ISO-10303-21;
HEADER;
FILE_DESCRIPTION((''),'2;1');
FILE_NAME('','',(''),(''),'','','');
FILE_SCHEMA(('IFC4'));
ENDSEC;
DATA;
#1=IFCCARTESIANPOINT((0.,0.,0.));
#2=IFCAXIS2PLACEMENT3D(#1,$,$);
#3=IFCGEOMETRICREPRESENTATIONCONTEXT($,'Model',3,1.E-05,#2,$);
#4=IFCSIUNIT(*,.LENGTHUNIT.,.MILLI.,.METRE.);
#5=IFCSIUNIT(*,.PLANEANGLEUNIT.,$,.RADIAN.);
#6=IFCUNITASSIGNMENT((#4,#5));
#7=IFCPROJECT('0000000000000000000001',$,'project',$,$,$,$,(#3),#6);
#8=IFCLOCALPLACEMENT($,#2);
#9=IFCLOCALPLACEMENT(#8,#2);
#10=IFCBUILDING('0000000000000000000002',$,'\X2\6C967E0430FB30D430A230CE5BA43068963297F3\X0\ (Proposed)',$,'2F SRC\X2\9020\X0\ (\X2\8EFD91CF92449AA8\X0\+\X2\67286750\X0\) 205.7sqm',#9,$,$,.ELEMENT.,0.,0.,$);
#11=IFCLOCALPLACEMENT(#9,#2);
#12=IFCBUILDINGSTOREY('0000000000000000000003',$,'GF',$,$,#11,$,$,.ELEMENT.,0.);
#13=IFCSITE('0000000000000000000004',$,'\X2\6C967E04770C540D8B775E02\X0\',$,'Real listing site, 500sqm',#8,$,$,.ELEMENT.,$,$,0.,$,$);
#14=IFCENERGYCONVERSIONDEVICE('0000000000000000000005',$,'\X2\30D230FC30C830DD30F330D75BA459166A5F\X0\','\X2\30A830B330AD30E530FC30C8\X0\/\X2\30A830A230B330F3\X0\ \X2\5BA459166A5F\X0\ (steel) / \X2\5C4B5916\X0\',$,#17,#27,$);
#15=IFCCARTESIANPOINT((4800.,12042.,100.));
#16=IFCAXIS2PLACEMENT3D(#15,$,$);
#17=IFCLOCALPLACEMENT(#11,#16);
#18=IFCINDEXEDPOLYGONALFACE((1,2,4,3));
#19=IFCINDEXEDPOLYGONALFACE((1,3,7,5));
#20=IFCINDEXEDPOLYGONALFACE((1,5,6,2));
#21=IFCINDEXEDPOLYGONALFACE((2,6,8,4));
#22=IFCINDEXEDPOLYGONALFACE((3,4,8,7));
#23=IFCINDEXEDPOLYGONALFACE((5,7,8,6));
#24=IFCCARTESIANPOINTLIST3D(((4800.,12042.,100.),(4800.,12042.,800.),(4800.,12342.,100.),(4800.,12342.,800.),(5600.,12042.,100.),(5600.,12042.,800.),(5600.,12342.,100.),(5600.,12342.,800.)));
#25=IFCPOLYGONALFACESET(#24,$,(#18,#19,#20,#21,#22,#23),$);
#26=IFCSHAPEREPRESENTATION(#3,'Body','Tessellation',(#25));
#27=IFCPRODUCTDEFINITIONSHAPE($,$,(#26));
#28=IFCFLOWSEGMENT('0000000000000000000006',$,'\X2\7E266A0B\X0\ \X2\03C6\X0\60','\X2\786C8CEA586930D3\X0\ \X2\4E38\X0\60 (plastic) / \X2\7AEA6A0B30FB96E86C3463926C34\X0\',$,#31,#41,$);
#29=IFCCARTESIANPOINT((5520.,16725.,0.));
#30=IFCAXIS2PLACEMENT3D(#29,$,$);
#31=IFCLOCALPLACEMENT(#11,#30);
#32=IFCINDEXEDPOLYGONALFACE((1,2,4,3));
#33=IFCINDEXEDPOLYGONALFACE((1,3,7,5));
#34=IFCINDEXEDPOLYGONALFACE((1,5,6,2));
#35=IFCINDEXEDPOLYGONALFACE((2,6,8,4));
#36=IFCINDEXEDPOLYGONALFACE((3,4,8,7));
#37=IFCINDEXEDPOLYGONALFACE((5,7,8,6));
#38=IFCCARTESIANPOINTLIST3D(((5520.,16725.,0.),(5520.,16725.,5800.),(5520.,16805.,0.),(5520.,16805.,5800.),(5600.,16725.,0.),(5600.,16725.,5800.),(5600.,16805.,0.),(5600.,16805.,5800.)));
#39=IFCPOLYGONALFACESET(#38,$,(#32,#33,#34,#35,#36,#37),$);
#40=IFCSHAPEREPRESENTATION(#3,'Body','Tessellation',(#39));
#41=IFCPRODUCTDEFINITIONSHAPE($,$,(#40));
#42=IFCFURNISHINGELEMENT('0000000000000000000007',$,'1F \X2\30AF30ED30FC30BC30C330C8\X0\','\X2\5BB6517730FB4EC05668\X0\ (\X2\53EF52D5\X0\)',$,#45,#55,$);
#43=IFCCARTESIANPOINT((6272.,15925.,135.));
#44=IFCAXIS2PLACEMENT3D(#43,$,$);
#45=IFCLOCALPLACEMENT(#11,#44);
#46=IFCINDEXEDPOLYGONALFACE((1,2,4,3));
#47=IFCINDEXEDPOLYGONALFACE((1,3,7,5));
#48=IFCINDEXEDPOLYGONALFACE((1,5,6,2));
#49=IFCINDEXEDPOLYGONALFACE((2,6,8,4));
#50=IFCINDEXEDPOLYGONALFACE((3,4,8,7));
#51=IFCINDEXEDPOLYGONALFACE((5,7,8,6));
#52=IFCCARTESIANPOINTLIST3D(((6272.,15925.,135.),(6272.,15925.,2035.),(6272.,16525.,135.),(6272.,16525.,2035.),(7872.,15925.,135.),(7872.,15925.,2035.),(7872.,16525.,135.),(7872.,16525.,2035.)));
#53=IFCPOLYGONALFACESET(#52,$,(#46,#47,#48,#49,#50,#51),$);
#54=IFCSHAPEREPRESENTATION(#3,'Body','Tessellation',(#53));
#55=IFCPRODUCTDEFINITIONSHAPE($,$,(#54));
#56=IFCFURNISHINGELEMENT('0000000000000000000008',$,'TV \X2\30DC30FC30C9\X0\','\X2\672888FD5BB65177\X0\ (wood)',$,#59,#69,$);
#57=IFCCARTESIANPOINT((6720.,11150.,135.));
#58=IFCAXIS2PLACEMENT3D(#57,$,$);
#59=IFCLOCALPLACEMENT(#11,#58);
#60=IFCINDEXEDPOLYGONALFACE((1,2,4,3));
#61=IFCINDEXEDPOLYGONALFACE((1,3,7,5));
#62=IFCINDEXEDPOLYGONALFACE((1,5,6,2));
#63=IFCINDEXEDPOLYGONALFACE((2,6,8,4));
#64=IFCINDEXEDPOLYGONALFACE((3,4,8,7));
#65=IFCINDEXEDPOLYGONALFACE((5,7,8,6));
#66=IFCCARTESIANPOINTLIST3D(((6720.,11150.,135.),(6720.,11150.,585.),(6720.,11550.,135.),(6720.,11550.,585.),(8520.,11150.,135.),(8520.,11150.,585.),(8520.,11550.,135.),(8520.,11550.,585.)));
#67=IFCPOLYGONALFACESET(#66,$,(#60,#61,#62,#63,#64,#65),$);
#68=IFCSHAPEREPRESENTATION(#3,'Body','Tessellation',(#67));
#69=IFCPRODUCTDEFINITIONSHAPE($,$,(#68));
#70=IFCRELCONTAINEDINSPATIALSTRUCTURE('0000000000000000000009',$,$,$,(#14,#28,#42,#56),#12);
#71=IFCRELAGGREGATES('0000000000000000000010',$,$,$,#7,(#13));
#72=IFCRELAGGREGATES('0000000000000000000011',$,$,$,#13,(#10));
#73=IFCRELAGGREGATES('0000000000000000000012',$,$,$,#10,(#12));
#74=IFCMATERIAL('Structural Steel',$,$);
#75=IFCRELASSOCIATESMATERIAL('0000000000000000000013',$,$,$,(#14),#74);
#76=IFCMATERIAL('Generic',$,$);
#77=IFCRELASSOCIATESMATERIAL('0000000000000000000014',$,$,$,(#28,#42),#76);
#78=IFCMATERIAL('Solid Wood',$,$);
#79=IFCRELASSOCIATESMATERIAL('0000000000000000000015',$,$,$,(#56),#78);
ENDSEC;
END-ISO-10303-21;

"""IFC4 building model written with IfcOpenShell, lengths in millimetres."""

from ifc_helpers import new_model, si_unit, frame, frame_2d, origin, place, context, project, spatial, rectangle, extrude, material, element, save


model = new_model("IFC4")

# Units and contexts
model_context = context("Model", 3, precision=1e-05, world=origin())
ifc_project = project(units=[si_unit("LENGTHUNIT", "METRE", prefix="MILLI"), si_unit("PLANEANGLEUNIT", "RADIAN")], contexts=[model_context])

# Site, building, storey
site_placement = place(None, origin())
site = spatial("IfcSite", under=ifc_project, at=site_placement, Name="沖縄県名護市", ObjectType="Real listing site, 500sqm", CompositionType="ELEMENT", RefElevation=0.0)
building_placement = place(site_placement, origin())
building = spatial("IfcBuilding", under=site, at=building_placement, Name="沖縄・ピアノ室と防音 (Proposed)", ObjectType="2F SRC造 (軽量鉄骨+木材) 205.7sqm", CompositionType="ELEMENT", ElevationOfRefHeight=0.0, ElevationOfTerrain=0.0)
storey_placement = place(building_placement, origin())
storey = spatial("IfcBuildingStorey", under=building, at=storey_placement, Name="GF", CompositionType="ELEMENT", Elevation=0.0)

# Shared definitions
ifc_material_1 = material(Name="Solid Wood")

# Shared definitions
ifc_material_2 = material(Name="Generic")

# Energy conversion device
ifc_material_3 = material(Name="Structural Steel")
energy_conversion_device_placement = place(storey_placement, frame((4800.0, 12042.0, 100.0)))
element("IfcEnergyConversionDevice", 1, at=energy_conversion_device_placement, inside=storey, material=ifc_material_3, Name="ヒートポンプ室外機", Description="エコキュート/エアコン 室外機 (steel) / 屋外", context=model_context, shape_type="SweptSolid", body=[
    extrude(rectangle(XDim=800.0, YDim=300.0, at=frame_2d((400.0, 150.0))), frame((4800.0, 12042.0, 100.0)), (0.0, 0.0, 1.0), 700.0),
])

# Flow segment
flow_segment_placement = place(storey_placement, frame((5520.0, 16725.0, 0.0)))
element("IfcFlowSegment", 2, at=flow_segment_placement, inside=storey, material=ifc_material_2, Name="縦樋 φ60", Description="硬質塩ビ 丸60 (plastic) / 竪樋・雨水排水", context=model_context, shape_type="SweptSolid", body=[
    extrude(rectangle(XDim=80.0, YDim=80.0, at=frame_2d((40.0, 40.0))), frame((5520.0, 16725.0, 0.0)), (0.0, 0.0, 1.0), 5800.0),
])

# Furnishing elements
furnishing_1_placement = place(storey_placement, frame((6272.0, 15925.0, 135.0)))
element("IfcFurnishingElement", 3, at=furnishing_1_placement, inside=storey, material=ifc_material_2, Name="1F クローゼット", Description="家具・什器 (可動)", context=model_context, shape_type="SweptSolid", body=[
    extrude(rectangle(XDim=1600.0, YDim=600.0, at=frame_2d((800.0, 300.0))), frame((6272.0, 15925.0, 135.0)), (0.0, 0.0, 1.0), 1900.0),
])
furnishing_2_placement = place(storey_placement, frame((6720.0, 11150.0, 135.0)))
element("IfcFurnishingElement", 4, at=furnishing_2_placement, inside=storey, material=ifc_material_1, Name="TV ボード", Description="木製家具 (wood)", context=model_context, shape_type="SweptSolid", body=[
    extrude(rectangle(XDim=1800.0, YDim=400.0, at=frame_2d((900.0, 200.0))), frame((6720.0, 11150.0, 135.0)), (0.0, 0.0, 1.0), 450.0),
])

save(model, "model.ifc")
